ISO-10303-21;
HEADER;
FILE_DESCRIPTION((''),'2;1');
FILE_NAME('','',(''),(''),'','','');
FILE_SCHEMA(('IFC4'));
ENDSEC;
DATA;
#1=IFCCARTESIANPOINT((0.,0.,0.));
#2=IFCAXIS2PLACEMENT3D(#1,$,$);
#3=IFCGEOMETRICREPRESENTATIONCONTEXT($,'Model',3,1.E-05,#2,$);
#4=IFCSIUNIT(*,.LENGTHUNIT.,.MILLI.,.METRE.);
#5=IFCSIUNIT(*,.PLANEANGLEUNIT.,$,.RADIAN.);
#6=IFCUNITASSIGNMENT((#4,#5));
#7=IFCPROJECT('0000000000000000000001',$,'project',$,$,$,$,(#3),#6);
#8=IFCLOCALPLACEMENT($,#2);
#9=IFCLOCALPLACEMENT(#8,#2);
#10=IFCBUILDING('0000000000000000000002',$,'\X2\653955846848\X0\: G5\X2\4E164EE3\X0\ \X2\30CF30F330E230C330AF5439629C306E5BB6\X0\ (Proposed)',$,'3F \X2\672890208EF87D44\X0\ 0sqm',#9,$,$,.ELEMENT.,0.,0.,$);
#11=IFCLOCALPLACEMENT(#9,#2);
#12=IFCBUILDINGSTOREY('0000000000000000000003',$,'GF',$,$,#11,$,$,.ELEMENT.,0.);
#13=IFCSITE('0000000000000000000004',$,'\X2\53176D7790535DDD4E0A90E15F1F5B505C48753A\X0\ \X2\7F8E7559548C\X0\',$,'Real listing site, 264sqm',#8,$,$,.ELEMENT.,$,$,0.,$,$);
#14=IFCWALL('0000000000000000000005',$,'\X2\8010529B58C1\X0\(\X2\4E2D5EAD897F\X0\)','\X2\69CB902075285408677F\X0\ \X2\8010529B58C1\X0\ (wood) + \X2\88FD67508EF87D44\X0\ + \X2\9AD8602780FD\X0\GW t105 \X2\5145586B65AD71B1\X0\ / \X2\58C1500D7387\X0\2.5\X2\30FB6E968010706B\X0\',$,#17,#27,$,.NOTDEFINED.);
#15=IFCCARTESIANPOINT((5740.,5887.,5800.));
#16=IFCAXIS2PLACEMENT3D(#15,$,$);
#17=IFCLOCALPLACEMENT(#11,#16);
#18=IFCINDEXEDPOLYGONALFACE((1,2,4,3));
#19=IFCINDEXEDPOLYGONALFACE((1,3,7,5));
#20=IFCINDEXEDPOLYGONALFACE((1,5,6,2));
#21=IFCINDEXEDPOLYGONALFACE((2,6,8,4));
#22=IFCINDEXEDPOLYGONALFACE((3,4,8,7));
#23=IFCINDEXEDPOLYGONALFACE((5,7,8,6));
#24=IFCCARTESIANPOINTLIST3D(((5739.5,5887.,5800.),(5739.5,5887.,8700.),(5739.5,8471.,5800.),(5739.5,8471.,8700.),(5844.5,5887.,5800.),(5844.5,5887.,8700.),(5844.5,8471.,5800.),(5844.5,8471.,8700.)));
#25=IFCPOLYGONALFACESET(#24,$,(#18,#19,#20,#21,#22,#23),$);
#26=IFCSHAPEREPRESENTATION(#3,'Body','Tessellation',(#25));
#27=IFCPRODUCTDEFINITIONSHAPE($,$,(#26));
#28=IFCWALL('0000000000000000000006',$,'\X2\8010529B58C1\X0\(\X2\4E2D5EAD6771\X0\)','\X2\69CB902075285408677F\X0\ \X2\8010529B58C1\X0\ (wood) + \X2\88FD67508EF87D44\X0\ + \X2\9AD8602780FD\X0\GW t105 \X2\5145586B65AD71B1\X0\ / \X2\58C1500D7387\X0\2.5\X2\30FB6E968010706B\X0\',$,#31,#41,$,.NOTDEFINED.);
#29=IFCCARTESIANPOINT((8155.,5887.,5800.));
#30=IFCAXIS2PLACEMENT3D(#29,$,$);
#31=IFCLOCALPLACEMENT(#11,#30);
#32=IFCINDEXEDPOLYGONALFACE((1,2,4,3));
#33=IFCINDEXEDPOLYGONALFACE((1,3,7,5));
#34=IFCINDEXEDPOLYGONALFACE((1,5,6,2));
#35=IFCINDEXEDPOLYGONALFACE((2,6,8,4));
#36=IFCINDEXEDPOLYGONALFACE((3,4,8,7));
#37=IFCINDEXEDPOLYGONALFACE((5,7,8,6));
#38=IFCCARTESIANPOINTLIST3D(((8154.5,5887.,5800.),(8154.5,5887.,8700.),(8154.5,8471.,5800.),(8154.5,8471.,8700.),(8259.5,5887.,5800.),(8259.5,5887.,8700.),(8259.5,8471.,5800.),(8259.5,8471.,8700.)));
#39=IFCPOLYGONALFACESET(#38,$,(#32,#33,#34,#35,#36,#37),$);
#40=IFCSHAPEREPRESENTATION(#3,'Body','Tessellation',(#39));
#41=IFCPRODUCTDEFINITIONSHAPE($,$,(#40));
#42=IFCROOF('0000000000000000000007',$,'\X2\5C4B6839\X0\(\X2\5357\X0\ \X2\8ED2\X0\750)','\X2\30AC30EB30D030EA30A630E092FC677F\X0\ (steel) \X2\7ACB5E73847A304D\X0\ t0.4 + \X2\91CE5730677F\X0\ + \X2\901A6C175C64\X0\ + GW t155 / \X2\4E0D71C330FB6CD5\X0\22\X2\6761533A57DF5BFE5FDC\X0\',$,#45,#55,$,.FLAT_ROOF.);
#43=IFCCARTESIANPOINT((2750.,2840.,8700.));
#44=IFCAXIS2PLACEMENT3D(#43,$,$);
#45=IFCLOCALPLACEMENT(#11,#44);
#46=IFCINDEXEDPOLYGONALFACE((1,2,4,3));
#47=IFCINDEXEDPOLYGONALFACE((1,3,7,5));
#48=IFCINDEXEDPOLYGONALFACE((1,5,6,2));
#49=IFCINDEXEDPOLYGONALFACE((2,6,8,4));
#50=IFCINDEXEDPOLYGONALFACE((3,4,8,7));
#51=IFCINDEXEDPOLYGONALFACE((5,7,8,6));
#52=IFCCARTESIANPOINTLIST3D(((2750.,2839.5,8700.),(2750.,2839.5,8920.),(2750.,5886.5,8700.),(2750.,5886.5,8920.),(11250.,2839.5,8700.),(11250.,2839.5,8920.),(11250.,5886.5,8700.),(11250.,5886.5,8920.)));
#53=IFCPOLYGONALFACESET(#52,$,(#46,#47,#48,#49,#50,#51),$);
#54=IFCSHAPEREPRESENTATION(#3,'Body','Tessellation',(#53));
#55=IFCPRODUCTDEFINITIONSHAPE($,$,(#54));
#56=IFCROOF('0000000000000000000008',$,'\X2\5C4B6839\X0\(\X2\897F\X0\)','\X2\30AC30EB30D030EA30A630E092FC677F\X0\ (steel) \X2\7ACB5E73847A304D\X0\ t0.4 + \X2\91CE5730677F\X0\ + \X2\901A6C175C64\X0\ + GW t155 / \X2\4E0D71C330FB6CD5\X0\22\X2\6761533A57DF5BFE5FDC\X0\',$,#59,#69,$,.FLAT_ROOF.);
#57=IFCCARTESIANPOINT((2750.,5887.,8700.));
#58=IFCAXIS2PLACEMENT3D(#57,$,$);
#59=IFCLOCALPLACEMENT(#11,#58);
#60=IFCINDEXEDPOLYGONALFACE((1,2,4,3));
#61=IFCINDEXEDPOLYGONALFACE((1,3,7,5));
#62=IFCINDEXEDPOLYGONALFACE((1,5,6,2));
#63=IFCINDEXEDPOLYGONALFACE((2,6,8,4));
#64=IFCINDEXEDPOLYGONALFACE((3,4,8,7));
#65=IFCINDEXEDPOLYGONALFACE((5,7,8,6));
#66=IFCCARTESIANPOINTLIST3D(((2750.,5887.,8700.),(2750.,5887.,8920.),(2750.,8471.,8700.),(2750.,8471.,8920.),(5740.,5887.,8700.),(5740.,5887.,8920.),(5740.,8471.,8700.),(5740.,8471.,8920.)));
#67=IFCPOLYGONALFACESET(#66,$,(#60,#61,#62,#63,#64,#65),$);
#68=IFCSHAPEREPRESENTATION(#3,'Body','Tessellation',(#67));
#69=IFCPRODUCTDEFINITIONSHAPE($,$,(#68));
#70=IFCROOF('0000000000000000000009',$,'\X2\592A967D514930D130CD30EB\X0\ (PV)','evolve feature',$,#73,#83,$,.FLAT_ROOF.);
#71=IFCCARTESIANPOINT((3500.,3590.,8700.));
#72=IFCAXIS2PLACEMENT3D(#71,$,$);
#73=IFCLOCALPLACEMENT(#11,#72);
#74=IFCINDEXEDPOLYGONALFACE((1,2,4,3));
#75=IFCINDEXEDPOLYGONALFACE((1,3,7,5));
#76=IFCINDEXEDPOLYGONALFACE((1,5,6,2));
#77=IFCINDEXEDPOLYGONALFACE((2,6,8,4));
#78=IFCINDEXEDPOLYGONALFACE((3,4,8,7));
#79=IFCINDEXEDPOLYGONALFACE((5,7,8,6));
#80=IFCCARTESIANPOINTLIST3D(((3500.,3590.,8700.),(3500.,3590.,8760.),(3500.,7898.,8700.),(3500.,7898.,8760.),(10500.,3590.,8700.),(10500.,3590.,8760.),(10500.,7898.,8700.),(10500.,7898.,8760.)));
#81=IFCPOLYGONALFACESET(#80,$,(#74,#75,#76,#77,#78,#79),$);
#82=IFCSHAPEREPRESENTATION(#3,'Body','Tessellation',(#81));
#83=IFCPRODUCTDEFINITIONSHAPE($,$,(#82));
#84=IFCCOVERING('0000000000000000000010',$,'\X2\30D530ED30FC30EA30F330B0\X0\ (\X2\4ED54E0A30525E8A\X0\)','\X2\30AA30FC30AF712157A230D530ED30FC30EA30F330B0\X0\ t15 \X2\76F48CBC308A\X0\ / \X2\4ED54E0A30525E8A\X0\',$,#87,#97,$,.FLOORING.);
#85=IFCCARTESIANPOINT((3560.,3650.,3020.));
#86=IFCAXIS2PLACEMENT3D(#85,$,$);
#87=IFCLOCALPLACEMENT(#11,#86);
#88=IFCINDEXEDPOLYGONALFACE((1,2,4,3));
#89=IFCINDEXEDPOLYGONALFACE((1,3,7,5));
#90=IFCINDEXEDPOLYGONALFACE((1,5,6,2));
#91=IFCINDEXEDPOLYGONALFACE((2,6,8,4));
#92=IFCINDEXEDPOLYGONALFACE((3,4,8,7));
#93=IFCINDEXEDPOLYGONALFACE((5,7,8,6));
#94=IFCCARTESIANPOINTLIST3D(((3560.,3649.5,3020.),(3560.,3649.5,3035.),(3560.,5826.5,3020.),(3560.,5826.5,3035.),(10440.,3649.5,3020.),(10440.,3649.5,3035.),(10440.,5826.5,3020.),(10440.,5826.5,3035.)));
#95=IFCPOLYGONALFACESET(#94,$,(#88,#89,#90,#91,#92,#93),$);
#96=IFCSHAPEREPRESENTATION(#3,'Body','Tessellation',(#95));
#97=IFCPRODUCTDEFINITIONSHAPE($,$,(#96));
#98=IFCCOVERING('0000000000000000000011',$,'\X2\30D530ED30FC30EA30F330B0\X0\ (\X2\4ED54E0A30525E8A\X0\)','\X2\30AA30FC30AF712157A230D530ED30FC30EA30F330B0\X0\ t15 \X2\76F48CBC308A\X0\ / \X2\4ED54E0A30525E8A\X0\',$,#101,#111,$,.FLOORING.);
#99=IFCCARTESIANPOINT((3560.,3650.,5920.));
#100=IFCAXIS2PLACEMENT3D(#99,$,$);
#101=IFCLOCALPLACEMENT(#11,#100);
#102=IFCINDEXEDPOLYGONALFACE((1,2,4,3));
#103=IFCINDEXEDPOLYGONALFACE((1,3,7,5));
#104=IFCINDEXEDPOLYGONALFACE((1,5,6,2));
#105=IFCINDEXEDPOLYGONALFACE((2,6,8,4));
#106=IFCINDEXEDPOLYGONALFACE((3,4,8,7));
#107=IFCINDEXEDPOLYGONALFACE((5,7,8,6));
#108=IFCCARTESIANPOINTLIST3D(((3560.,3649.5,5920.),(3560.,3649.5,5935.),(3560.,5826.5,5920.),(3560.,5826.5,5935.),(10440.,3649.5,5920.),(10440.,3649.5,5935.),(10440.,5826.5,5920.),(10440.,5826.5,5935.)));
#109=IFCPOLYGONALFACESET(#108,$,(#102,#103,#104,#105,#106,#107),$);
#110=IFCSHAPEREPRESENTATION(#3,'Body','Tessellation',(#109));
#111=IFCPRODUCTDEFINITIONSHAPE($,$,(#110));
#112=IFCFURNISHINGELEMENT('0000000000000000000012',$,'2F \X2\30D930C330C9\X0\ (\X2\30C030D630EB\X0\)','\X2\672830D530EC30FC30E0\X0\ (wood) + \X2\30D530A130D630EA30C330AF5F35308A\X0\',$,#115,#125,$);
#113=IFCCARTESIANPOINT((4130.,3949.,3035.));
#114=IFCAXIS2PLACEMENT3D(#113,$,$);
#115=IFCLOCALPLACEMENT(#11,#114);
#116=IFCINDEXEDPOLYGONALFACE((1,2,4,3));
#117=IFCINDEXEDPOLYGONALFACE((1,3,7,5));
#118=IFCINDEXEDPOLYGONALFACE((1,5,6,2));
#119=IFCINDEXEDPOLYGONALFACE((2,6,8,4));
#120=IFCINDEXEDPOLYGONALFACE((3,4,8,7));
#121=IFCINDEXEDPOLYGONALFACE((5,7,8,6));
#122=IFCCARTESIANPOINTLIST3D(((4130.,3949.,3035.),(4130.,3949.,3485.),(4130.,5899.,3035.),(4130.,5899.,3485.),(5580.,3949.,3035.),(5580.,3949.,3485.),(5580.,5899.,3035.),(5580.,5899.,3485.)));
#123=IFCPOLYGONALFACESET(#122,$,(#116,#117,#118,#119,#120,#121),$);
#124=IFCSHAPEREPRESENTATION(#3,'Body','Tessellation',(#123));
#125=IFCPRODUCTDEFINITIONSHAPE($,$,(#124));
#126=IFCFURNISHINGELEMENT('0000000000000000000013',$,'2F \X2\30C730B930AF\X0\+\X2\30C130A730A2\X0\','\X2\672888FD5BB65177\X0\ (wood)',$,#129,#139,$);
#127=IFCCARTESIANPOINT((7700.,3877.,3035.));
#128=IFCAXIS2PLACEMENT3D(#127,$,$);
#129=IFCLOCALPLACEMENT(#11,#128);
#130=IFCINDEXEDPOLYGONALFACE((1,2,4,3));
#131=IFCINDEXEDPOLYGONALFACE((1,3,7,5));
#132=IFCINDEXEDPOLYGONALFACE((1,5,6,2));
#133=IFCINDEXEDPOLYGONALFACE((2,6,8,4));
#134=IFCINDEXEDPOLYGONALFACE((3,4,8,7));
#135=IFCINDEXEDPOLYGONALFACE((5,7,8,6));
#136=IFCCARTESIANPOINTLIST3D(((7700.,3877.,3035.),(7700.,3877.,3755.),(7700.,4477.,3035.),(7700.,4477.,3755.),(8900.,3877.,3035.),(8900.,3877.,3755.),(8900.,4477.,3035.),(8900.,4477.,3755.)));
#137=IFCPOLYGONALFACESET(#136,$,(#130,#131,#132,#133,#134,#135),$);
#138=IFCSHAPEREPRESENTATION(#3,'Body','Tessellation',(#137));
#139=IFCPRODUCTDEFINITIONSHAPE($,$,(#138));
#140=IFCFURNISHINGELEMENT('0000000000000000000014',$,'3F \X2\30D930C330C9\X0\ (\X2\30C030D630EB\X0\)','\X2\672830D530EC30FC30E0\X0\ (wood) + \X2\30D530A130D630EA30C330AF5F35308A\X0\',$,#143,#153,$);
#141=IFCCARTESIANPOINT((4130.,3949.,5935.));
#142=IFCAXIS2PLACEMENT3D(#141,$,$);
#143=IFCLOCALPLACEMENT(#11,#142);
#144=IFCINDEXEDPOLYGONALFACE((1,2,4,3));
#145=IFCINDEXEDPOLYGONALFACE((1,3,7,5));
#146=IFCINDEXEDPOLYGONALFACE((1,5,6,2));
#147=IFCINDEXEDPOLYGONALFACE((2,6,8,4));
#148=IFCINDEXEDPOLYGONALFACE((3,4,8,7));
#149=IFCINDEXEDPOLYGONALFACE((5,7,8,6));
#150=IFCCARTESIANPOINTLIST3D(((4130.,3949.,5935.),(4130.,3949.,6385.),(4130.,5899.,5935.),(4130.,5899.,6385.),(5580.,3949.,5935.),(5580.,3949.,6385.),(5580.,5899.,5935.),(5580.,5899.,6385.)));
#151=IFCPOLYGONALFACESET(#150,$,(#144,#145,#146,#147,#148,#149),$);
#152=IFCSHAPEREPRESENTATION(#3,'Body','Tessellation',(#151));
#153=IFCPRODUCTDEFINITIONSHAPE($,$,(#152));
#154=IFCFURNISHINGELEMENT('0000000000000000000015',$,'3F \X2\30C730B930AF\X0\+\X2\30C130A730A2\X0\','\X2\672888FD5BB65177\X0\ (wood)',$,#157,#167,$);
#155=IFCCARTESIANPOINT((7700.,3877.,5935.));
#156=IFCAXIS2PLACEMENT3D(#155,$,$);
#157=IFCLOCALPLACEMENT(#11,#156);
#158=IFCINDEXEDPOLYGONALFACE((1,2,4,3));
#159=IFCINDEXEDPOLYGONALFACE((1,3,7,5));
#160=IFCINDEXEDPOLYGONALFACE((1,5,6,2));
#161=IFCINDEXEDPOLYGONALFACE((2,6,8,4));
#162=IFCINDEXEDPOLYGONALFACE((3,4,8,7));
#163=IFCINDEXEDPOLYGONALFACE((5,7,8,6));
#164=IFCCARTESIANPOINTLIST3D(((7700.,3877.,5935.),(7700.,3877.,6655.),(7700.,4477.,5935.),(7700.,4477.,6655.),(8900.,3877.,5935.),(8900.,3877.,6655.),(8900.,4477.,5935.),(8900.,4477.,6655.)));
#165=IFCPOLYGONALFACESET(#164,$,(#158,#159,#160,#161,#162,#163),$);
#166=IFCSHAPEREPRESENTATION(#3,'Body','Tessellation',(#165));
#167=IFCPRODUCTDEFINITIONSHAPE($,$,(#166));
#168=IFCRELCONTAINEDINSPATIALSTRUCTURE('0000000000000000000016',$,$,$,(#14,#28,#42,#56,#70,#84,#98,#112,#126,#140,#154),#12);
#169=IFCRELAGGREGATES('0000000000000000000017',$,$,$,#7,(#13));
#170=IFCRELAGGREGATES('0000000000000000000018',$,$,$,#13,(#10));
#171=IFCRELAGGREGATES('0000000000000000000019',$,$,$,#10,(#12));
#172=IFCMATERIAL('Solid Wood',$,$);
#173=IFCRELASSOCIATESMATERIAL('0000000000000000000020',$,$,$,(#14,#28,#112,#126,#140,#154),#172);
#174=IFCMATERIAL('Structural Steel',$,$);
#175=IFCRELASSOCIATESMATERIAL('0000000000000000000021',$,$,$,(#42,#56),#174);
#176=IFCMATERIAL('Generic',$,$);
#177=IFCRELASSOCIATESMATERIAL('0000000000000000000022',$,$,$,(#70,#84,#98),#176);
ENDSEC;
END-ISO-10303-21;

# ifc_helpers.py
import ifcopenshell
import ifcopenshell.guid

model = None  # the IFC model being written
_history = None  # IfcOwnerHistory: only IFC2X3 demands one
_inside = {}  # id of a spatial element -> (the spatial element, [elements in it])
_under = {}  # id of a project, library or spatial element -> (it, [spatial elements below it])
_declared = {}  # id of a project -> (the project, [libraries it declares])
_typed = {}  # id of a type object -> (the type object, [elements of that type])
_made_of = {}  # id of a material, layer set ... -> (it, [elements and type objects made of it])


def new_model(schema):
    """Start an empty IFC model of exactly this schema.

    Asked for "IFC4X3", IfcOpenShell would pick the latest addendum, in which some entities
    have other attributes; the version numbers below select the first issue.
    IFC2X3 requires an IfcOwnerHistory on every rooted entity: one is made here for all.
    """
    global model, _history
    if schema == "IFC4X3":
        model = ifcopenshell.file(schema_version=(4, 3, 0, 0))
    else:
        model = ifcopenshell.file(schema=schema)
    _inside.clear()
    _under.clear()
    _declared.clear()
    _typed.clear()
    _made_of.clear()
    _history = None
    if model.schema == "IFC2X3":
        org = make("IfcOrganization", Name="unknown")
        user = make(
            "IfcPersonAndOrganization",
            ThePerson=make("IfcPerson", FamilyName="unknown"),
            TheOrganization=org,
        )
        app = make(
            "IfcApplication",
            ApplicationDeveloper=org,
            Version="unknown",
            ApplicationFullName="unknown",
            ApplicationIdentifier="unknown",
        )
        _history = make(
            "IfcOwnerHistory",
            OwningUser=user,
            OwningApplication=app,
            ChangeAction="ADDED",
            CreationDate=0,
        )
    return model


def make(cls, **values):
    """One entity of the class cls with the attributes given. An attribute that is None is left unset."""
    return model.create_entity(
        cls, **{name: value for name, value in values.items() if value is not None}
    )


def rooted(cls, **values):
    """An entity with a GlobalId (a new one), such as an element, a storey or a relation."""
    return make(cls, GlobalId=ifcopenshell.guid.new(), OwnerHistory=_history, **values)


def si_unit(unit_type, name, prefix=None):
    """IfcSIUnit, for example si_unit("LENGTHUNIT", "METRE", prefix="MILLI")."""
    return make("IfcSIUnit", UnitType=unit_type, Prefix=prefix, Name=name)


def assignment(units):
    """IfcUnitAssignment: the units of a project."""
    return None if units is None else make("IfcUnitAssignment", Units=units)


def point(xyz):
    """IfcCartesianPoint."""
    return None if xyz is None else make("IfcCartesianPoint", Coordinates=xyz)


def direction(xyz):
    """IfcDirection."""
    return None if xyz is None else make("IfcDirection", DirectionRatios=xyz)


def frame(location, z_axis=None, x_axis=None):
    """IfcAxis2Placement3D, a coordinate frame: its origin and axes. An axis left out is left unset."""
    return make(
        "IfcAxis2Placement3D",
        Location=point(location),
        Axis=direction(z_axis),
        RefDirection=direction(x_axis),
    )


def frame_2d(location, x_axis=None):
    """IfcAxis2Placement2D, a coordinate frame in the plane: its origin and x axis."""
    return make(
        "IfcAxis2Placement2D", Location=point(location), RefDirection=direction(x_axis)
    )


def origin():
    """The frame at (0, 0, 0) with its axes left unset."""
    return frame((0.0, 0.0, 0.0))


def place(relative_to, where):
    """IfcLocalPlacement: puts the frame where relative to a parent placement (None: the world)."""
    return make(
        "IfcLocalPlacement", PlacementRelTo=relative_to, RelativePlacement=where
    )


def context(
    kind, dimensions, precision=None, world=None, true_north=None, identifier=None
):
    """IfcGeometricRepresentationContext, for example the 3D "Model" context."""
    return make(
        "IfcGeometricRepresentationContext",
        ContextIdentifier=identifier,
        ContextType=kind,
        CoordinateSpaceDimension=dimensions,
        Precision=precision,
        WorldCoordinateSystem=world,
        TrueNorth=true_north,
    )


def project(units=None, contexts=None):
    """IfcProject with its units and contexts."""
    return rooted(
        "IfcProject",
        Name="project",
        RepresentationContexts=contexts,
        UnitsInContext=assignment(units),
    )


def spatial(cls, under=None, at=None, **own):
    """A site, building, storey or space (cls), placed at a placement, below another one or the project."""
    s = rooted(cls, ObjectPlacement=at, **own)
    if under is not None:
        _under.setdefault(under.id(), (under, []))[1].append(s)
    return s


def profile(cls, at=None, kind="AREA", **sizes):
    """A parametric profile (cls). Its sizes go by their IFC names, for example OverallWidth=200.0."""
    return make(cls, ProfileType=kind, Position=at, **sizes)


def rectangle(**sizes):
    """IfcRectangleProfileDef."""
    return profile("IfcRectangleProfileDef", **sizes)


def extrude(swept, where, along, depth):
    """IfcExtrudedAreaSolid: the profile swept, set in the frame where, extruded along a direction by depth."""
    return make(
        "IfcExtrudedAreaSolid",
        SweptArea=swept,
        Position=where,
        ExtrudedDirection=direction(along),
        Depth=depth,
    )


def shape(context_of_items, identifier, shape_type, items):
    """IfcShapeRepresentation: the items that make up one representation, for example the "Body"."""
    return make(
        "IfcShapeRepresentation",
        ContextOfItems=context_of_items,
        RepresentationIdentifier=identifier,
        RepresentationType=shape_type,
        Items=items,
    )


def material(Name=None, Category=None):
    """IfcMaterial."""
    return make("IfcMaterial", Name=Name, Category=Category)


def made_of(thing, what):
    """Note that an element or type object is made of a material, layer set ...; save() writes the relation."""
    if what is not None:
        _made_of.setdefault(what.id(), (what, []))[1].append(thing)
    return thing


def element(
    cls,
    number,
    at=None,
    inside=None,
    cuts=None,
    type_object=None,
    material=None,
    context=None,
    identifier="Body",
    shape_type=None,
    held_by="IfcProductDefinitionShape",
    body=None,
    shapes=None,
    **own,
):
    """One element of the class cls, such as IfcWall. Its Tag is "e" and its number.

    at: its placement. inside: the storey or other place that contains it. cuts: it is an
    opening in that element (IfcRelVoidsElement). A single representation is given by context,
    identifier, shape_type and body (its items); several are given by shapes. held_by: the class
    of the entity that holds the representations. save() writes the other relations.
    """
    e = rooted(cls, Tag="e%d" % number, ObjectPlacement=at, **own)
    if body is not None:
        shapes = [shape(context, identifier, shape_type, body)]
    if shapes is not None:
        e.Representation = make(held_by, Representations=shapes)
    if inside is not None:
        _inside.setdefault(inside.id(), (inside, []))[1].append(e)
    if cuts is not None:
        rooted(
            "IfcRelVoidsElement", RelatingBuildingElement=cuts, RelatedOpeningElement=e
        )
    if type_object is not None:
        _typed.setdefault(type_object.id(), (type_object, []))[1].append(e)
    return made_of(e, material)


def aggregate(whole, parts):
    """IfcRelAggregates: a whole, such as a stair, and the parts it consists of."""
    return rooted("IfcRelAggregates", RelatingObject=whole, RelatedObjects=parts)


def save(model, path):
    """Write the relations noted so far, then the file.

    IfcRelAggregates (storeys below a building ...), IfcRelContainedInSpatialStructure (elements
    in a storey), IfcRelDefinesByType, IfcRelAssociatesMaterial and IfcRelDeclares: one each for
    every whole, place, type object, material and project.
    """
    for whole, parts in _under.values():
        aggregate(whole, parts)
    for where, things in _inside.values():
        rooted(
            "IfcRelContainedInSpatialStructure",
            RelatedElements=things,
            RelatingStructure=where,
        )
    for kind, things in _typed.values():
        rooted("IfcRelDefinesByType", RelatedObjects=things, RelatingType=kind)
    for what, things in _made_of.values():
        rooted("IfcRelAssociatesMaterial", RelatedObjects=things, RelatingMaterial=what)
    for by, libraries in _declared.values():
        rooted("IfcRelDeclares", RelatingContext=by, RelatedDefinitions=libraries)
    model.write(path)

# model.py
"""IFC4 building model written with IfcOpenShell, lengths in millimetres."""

from ifc_helpers import new_model, si_unit, frame, frame_2d, origin, place, context, project, spatial, rectangle, extrude, material, element, save


model = new_model("IFC4")

# Units and contexts
model_context = context("Model", 3, precision=1e-05, world=origin())
ifc_project = project(units=[si_unit("LENGTHUNIT", "METRE", prefix="MILLI"), si_unit("PLANEANGLEUNIT", "RADIAN")], contexts=[model_context])

# Site, building, storey
site_placement = place(None, origin())
site = spatial("IfcSite", under=ifc_project, at=site_placement, Name="北海道川上郡弟子屈町 美留和", ObjectType="Real listing site, 264sqm", CompositionType="ELEMENT", RefElevation=0.0)
building_placement = place(site_placement, origin())
building = spatial("IfcBuilding", under=site, at=building_placement, Name="改善案: G5世代 ハンモック吹抜の家 (Proposed)", ObjectType="3F 木造軸組 0sqm", CompositionType="ELEMENT", ElevationOfRefHeight=0.0, ElevationOfTerrain=0.0)
storey_placement = place(building_placement, origin())
storey = spatial("IfcBuildingStorey", under=building, at=storey_placement, Name="GF", CompositionType="ELEMENT", Elevation=0.0)

# Shared definitions
ifc_material_1 = material(Name="Solid Wood")

# Walls
wall_1_placement = place(storey_placement, frame((5740.0, 5887.0, 5800.0)))
element("IfcWall", 1, at=wall_1_placement, inside=storey, material=ifc_material_1, Name="耐力壁(中庭西)", Description="構造用合板 耐力壁 (wood) + 製材軸組 + 高性能GW t105 充填断熱 / 壁倍率2.5・準耐火", PredefinedType="NOTDEFINED", context=model_context, shape_type="SweptSolid", body=[
    extrude(rectangle(XDim=105.0, YDim=2584.0, at=frame_2d((52.0, 1292.0))), frame((5740.0, 5887.0, 5800.0)), (0.0, 0.0, 1.0), 2900.0),
])
wall_2_placement = place(storey_placement, frame((8155.0, 5887.0, 5800.0)))
element("IfcWall", 2, at=wall_2_placement, inside=storey, material=ifc_material_1, Name="耐力壁(中庭東)", Description="構造用合板 耐力壁 (wood) + 製材軸組 + 高性能GW t105 充填断熱 / 壁倍率2.5・準耐火", PredefinedType="NOTDEFINED", context=model_context, shape_type="SweptSolid", body=[
    extrude(rectangle(XDim=105.0, YDim=2584.0, at=frame_2d((52.0, 1292.0))), frame((8155.0, 5887.0, 5800.0)), (0.0, 0.0, 1.0), 2900.0),
])

# Roofs
ifc_material_2 = material(Name="Structural Steel")
roof_1_placement = place(storey_placement, frame((2750.0, 2840.0, 8700.0)))
element("IfcRoof", 3, at=roof_1_placement, inside=storey, material=ifc_material_2, Name="屋根(南 軒750)", Description="ガルバリウム鋼板 (steel) 立平葺き t0.4 + 野地板 + 通気層 + GW t155 / 不燃・法22条区域対応", PredefinedType="FLAT_ROOF", context=model_context, shape_type="SweptSolid", body=[
    extrude(rectangle(XDim=8500.0, YDim=3047.0, at=frame_2d((4250.0, 1523.0))), frame((2750.0, 2840.0, 8700.0)), (0.0, 0.0, 1.0), 220.0),
])
roof_2_placement = place(storey_placement, frame((2750.0, 5887.0, 8700.0)))
element("IfcRoof", 4, at=roof_2_placement, inside=storey, material=ifc_material_2, Name="屋根(西)", Description="ガルバリウム鋼板 (steel) 立平葺き t0.4 + 野地板 + 通気層 + GW t155 / 不燃・法22条区域対応", PredefinedType="FLAT_ROOF", context=model_context, shape_type="SweptSolid", body=[
    extrude(rectangle(XDim=2990.0, YDim=2584.0, at=frame_2d((1495.0, 1292.0))), frame((2750.0, 5887.0, 8700.0)), (0.0, 0.0, 1.0), 220.0),
])
ifc_material_3 = material(Name="Generic")
roof_3_placement = place(storey_placement, frame((3500.0, 3590.0, 8700.0)))
element("IfcRoof", 5, at=roof_3_placement, inside=storey, material=ifc_material_3, Name="太陽光パネル (PV)", Description="evolve feature", PredefinedType="FLAT_ROOF", context=model_context, shape_type="SweptSolid", body=[
    extrude(rectangle(XDim=7000.0, YDim=4308.0, at=frame_2d((3500.0, 2154.0))), frame((3500.0, 3590.0, 8700.0)), (0.0, 0.0, 1.0), 60.0),
])

# Coverings
covering_1_placement = place(storey_placement, frame((3560.0, 3650.0, 3020.0)))
element("IfcCovering", 6, at=covering_1_placement, inside=storey, material=ifc_material_3, Name="フローリング (仕上げ床)", Description="オーク無垢フローリング t15 直貼り / 仕上げ床", PredefinedType="FLOORING", context=model_context, shape_type="SweptSolid", body=[
    extrude(rectangle(XDim=6880.0, YDim=2177.0, at=frame_2d((3440.0, 1088.0))), frame((3560.0, 3650.0, 3020.0)), (0.0, 0.0, 1.0), 15.0),
])
covering_2_placement = place(storey_placement, frame((3560.0, 3650.0, 5920.0)))
element("IfcCovering", 7, at=covering_2_placement, inside=storey, material=ifc_material_3, Name="フローリング (仕上げ床)", Description="オーク無垢フローリング t15 直貼り / 仕上げ床", PredefinedType="FLOORING", context=model_context, shape_type="SweptSolid", body=[
    extrude(rectangle(XDim=6880.0, YDim=2177.0, at=frame_2d((3440.0, 1088.0))), frame((3560.0, 3650.0, 5920.0)), (0.0, 0.0, 1.0), 15.0),
])

# Furnishing elements
furnishing_1_placement = place(storey_placement, frame((4130.0, 3949.0, 3035.0)))
element("IfcFurnishingElement", 8, at=furnishing_1_placement, inside=storey, material=ifc_material_1, Name="2F ベッド (ダブル)", Description="木フレーム (wood) + ファブリック張り", context=model_context, shape_type="SweptSolid", body=[
    extrude(rectangle(XDim=1450.0, YDim=1950.0, at=frame_2d((725.0, 975.0))), frame((4130.0, 3949.0, 3035.0)), (0.0, 0.0, 1.0), 450.0),
])
furnishing_2_placement = place(storey_placement, frame((7700.0, 3877.0, 3035.0)))
element("IfcFurnishingElement", 9, at=furnishing_2_placement, inside=storey, material=ifc_material_1, Name="2F デスク+チェア", Description="木製家具 (wood)", context=model_context, shape_type="SweptSolid", body=[
    extrude(rectangle(XDim=1200.0, YDim=600.0, at=frame_2d((600.0, 300.0))), frame((7700.0, 3877.0, 3035.0)), (0.0, 0.0, 1.0), 720.0),
])
furnishing_3_placement = place(storey_placement, frame((4130.0, 3949.0, 5935.0)))
element("IfcFurnishingElement", 10, at=furnishing_3_placement, inside=storey, material=ifc_material_1, Name="3F ベッド (ダブル)", Description="木フレーム (wood) + ファブリック張り", context=model_context, shape_type="SweptSolid", body=[
    extrude(rectangle(XDim=1450.0, YDim=1950.0, at=frame_2d((725.0, 975.0))), frame((4130.0, 3949.0, 5935.0)), (0.0, 0.0, 1.0), 450.0),
])
furnishing_4_placement = place(storey_placement, frame((7700.0, 3877.0, 5935.0)))
element("IfcFurnishingElement", 11, at=furnishing_4_placement, inside=storey, material=ifc_material_1, Name="3F デスク+チェア", Description="木製家具 (wood)", context=model_context, shape_type="SweptSolid", body=[
    extrude(rectangle(XDim=1200.0, YDim=600.0, at=frame_2d((600.0, 300.0))), frame((7700.0, 3877.0, 5935.0)), (0.0, 0.0, 1.0), 720.0),
])

save(model, "model.ifc")
